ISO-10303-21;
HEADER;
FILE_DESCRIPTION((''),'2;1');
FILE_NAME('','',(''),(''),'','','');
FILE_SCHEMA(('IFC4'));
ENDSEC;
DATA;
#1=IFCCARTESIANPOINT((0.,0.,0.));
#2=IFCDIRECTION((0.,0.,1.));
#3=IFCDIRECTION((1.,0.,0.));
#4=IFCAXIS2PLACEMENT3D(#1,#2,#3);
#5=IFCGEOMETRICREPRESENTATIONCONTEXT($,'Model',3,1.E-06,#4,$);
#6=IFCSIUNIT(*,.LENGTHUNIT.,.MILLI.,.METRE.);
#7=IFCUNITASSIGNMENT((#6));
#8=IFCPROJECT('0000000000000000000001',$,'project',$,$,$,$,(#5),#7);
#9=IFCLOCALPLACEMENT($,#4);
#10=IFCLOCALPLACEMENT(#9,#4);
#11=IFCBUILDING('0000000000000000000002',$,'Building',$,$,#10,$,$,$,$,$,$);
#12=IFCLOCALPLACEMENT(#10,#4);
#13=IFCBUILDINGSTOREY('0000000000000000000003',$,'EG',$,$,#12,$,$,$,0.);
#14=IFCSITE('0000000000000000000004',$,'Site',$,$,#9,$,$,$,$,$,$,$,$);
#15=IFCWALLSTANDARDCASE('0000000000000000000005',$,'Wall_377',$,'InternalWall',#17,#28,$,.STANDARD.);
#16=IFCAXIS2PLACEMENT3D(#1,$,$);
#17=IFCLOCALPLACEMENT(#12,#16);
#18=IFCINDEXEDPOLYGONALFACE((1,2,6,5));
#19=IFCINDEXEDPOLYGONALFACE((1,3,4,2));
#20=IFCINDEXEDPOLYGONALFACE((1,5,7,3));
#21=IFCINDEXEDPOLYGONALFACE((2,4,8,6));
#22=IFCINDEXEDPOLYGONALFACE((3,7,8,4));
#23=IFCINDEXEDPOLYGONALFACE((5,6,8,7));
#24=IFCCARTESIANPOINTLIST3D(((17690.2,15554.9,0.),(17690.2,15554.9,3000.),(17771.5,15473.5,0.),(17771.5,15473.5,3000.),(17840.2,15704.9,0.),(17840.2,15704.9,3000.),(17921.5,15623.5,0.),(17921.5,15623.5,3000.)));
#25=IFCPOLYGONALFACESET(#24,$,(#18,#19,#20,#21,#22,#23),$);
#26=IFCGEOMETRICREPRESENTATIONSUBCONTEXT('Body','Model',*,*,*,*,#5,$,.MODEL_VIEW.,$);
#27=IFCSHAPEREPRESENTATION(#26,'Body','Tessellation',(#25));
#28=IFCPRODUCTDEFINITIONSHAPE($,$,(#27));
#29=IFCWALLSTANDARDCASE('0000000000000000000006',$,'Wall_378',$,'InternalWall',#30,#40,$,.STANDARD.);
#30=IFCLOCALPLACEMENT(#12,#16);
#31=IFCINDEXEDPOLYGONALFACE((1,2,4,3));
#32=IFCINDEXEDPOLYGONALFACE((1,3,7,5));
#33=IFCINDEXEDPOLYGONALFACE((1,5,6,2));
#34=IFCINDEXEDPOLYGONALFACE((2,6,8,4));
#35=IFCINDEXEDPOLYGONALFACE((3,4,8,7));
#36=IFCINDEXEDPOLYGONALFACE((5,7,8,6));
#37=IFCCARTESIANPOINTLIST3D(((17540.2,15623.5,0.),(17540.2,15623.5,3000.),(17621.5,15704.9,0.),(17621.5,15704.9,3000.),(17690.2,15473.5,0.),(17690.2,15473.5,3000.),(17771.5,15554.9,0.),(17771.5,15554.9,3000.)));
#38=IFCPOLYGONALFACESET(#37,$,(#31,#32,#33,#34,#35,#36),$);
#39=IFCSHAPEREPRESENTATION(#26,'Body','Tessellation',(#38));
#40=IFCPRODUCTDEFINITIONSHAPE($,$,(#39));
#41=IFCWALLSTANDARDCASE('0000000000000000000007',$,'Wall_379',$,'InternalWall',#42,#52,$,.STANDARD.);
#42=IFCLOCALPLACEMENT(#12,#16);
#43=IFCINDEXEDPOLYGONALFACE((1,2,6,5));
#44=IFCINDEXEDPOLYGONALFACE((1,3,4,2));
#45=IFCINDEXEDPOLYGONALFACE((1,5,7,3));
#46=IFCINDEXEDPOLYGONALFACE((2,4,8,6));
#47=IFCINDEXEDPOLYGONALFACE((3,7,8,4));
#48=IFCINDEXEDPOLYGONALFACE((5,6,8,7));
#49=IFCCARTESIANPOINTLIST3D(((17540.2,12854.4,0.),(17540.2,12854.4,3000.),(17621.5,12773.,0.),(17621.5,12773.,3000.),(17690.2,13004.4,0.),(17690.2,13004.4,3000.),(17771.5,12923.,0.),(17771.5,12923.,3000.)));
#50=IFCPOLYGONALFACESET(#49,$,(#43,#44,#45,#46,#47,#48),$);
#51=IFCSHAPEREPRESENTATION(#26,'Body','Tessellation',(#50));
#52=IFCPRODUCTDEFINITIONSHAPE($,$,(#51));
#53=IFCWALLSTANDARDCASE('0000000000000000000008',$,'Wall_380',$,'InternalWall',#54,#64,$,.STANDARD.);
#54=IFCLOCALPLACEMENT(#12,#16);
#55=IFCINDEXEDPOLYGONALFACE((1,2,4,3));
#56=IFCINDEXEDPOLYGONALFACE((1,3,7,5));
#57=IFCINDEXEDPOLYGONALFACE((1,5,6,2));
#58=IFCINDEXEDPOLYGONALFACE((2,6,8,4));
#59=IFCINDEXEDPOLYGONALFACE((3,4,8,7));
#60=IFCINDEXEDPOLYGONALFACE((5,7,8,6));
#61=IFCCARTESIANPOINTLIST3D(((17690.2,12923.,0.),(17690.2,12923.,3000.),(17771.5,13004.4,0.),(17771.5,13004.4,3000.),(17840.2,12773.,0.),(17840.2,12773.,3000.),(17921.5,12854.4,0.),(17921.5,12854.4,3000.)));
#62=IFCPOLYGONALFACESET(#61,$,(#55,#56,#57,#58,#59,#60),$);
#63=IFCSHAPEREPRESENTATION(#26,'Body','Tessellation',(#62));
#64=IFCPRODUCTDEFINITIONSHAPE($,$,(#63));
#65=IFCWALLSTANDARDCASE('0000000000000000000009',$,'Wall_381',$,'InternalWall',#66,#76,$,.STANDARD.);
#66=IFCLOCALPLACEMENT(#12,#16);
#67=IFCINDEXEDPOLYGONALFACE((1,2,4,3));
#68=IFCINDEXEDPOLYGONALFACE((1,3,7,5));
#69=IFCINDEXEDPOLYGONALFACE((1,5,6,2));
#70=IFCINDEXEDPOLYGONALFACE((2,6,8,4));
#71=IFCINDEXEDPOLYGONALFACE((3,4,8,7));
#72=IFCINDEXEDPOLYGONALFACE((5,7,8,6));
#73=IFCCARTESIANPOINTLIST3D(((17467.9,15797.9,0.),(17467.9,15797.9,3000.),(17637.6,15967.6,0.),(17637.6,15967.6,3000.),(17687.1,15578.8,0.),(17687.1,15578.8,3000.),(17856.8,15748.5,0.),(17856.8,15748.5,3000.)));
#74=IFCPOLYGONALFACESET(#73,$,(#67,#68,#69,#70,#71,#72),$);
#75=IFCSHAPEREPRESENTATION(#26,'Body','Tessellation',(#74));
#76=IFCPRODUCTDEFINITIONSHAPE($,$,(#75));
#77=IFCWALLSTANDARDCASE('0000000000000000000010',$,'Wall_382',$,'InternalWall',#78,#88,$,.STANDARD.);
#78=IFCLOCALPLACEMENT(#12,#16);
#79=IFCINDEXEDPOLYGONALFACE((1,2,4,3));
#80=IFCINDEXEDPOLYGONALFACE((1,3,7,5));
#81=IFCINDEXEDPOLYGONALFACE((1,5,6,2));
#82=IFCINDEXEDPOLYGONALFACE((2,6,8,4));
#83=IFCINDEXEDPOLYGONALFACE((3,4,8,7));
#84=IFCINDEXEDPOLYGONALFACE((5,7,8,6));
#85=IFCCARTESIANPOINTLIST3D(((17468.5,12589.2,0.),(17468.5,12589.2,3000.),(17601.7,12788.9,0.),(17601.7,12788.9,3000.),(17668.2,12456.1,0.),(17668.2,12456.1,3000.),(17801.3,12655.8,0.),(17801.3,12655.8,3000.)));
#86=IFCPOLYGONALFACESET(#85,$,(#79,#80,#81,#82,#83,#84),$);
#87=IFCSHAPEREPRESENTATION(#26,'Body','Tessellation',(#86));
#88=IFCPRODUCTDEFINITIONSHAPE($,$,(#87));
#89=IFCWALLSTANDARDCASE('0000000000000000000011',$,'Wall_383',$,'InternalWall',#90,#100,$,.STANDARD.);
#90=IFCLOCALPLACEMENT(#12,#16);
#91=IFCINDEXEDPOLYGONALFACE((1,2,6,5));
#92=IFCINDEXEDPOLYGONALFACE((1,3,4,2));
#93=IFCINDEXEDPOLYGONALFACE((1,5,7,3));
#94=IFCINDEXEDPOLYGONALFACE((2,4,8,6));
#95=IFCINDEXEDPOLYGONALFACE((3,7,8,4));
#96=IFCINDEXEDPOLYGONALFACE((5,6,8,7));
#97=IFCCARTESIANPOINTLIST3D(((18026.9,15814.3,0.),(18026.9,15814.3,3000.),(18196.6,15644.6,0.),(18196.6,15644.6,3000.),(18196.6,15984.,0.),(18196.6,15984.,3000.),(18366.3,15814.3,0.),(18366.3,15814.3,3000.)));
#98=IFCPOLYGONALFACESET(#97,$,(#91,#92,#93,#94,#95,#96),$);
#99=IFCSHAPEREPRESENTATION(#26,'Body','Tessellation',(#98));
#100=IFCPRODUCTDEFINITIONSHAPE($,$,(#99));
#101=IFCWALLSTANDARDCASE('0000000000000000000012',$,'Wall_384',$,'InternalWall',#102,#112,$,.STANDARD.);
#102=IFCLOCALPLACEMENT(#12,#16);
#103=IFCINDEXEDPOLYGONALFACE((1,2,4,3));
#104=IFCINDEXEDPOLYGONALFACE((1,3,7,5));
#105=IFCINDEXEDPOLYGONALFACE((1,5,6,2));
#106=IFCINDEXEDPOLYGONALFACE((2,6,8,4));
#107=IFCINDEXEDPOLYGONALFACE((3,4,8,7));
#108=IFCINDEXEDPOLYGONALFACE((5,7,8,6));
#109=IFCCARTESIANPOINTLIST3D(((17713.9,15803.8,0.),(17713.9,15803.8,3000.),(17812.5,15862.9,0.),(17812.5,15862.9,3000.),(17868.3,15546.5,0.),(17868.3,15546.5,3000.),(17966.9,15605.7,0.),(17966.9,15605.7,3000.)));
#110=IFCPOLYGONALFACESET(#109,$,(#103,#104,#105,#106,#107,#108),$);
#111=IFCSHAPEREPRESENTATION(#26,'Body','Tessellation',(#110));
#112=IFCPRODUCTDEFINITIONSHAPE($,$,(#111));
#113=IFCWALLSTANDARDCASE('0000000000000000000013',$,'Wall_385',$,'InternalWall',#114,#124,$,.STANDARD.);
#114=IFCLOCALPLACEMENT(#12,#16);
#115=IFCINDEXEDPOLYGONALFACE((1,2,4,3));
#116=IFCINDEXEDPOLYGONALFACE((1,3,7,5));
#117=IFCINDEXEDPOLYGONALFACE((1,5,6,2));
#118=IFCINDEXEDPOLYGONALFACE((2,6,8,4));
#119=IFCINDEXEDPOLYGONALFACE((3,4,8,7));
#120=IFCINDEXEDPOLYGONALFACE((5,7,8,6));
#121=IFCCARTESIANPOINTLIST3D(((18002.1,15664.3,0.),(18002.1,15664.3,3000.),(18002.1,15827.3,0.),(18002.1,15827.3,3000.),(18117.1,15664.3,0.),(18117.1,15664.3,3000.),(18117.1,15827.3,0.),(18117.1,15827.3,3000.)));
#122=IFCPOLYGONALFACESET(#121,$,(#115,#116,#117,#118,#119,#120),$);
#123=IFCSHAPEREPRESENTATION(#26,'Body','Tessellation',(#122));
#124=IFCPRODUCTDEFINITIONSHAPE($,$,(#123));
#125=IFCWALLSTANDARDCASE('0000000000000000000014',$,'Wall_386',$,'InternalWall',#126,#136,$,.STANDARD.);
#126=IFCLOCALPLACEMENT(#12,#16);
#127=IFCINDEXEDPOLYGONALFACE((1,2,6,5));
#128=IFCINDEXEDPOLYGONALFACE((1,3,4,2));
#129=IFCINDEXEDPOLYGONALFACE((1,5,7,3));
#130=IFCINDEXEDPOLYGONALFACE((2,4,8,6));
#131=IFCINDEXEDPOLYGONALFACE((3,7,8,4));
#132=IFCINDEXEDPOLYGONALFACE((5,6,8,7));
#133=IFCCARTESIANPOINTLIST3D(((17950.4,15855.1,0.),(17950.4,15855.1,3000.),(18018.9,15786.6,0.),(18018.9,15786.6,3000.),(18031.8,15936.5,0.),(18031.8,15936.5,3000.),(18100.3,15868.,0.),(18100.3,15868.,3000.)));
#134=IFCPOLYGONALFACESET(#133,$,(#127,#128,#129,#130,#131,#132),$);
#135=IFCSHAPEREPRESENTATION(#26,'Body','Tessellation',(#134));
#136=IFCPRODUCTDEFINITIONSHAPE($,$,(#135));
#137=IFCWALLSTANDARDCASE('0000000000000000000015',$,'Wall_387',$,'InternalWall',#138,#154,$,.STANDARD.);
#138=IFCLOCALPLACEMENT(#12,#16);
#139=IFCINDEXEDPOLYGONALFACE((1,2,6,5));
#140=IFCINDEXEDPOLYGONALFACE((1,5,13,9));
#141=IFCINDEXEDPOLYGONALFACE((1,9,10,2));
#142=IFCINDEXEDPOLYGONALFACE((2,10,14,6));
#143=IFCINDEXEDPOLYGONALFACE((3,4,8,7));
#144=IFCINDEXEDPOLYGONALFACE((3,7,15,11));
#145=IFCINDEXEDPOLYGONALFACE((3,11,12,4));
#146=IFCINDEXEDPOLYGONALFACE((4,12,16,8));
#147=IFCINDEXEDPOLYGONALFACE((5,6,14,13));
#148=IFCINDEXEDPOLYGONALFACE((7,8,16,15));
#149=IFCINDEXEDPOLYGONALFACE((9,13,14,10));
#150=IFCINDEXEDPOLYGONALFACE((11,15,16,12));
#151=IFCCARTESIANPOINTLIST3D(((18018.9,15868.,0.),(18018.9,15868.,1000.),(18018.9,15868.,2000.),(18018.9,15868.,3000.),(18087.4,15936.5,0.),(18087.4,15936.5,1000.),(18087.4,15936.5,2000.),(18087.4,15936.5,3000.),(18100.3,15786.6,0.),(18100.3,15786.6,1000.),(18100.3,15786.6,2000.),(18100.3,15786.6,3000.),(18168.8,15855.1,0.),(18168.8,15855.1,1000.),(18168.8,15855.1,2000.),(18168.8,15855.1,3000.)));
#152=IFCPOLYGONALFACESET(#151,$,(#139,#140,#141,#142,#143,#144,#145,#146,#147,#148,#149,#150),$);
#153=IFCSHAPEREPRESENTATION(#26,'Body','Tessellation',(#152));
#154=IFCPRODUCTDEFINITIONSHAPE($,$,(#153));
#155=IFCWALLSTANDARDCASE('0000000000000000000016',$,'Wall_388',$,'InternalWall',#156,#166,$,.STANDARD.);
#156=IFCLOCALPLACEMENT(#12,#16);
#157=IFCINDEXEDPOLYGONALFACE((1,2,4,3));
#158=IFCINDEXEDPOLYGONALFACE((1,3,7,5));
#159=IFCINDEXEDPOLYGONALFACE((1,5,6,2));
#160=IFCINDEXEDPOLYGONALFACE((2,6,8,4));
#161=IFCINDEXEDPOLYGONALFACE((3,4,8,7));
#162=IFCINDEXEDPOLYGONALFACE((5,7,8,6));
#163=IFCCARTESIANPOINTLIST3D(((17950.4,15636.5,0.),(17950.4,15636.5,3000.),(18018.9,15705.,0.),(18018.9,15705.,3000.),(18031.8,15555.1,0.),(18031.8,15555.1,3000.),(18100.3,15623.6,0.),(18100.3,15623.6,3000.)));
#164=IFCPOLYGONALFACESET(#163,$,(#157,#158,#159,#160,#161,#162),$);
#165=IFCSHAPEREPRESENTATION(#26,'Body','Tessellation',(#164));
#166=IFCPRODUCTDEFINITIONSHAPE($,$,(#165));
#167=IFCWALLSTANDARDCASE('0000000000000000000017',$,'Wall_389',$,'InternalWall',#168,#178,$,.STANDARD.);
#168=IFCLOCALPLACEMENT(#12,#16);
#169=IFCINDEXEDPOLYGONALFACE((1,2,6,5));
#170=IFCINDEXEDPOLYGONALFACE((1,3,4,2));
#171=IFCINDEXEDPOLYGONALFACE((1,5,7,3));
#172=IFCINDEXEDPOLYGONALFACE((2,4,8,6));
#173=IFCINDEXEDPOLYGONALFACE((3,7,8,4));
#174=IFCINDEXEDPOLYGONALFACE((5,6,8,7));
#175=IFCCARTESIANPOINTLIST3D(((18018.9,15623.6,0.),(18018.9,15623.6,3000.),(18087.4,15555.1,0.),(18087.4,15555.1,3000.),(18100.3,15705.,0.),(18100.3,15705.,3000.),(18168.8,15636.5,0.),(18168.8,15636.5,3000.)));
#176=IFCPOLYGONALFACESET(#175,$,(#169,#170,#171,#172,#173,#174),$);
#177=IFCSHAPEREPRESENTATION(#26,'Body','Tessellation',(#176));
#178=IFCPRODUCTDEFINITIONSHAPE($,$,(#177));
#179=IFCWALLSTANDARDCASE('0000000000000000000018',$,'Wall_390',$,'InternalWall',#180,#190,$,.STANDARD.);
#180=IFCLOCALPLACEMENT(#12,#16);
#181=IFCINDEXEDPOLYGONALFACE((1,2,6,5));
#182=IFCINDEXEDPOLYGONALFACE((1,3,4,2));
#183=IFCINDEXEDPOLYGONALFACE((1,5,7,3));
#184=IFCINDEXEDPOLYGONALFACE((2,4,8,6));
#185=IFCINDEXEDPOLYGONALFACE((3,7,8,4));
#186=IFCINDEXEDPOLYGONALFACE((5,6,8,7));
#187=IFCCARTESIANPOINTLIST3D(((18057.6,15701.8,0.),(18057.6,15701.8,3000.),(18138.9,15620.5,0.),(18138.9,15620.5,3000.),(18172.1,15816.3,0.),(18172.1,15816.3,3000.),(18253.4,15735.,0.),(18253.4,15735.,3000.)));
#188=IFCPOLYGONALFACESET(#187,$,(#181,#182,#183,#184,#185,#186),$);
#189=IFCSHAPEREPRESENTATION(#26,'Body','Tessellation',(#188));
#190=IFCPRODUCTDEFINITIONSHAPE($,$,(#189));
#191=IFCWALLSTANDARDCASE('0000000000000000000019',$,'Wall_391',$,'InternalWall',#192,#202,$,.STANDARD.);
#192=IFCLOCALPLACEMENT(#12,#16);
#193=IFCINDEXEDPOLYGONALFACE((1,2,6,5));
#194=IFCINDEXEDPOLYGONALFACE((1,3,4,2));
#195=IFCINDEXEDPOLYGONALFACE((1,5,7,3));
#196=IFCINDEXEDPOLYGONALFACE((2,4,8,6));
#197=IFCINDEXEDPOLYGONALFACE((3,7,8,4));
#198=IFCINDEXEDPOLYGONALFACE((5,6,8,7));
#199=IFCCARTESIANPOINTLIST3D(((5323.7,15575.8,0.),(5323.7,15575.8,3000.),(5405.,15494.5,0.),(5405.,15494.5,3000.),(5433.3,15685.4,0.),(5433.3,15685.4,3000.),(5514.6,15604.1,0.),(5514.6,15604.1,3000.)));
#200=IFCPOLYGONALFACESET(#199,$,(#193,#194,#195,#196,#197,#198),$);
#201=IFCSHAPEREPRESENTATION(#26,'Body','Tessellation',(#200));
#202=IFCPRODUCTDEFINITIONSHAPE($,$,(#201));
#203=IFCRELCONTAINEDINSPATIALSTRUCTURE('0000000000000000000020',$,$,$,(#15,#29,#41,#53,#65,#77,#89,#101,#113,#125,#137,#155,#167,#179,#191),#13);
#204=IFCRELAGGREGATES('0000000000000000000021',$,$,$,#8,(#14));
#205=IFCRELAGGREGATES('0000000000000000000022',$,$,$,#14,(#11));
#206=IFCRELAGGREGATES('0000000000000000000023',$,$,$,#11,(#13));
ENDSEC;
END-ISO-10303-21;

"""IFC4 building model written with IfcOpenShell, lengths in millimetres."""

from ifc_helpers import new_model, si_unit, frame, origin_with_axes, place, context, subcontext, project, spatial, rectangle, extrude, element, save


model = new_model("IFC4")

# Units and contexts
model_context = context("Model", 3, precision=1e-06, world=origin_with_axes())
body_context = subcontext(model_context, "Body", "Model", "MODEL_VIEW")
ifc_project = project(units=[si_unit("LENGTHUNIT", "METRE", prefix="MILLI")], contexts=[model_context])

# Site, building, storey
site_placement = place(None, origin_with_axes())
site = spatial("IfcSite", under=ifc_project, at=site_placement, Name="Site")
building_placement = place(site_placement, origin_with_axes())
building = spatial("IfcBuilding", under=site, at=building_placement, Name="Building")
storey_placement = place(building_placement, origin_with_axes())
storey = spatial("IfcBuildingStorey", under=building, at=storey_placement, Name="EG", Elevation=0.0)

# Walls
wall_1_placement = place(storey_placement, origin_with_axes())
element("IfcWallStandardCase", 1, at=wall_1_placement, inside=storey, Name="Wall_377", ObjectType="InternalWall", PredefinedType="STANDARD", context=body_context, shape_type="SweptSolid", body=[
    extrude(rectangle(XDim=212.1, YDim=115.0), frame((17805.8, 15589.2, 0.0), z_axis=(0.0, 0.0, 1.0), x_axis=(-0.707107, -0.707107, 0.0)), (0.0, 0.0, 1.0), 3000.0),
])
wall_2_placement = place(storey_placement, origin_with_axes())
element("IfcWallStandardCase", 2, at=wall_2_placement, inside=storey, Name="Wall_378", ObjectType="InternalWall", PredefinedType="STANDARD", context=body_context, shape_type="SweptSolid", body=[
    extrude(rectangle(XDim=212.1, YDim=115.0), frame((17655.8, 15589.2, 0.0), z_axis=(0.0, 0.0, 1.0), x_axis=(-0.707107, 0.707107, 0.0)), (0.0, 0.0, 1.0), 3000.0),
])
wall_3_placement = place(storey_placement, origin_with_axes())
element("IfcWallStandardCase", 3, at=wall_3_placement, inside=storey, Name="Wall_379", ObjectType="InternalWall", PredefinedType="STANDARD", context=body_context, shape_type="SweptSolid", body=[
    extrude(rectangle(XDim=212.1, YDim=115.0), frame((17655.8, 12888.7, 0.0), z_axis=(0.0, 0.0, 1.0), x_axis=(-0.707107, -0.707107, 0.0)), (0.0, 0.0, 1.0), 3000.0),
])
wall_4_placement = place(storey_placement, origin_with_axes())
element("IfcWallStandardCase", 4, at=wall_4_placement, inside=storey, Name="Wall_380", ObjectType="InternalWall", PredefinedType="STANDARD", context=body_context, shape_type="SweptSolid", body=[
    extrude(rectangle(XDim=212.1, YDim=115.0), frame((17805.8, 12888.7, 0.0), z_axis=(0.0, 0.0, 1.0), x_axis=(0.707107, -0.707107, 0.0)), (0.0, 0.0, 1.0), 3000.0),
])
wall_5_placement = place(storey_placement, origin_with_axes())
element("IfcWallStandardCase", 5, at=wall_5_placement, inside=storey, Name="Wall_381", ObjectType="InternalWall", PredefinedType="STANDARD", context=body_context, shape_type="SweptSolid", body=[
    extrude(rectangle(XDim=310.0, YDim=240.0), frame((17662.3, 15773.2, 0.0), z_axis=(0.0, 0.0, 1.0), x_axis=(-0.707107, 0.707107, 0.0)), (0.0, 0.0, 1.0), 3000.0),
])
wall_6_placement = place(storey_placement, origin_with_axes())
element("IfcWallStandardCase", 6, at=wall_6_placement, inside=storey, Name="Wall_382", ObjectType="InternalWall", PredefinedType="STANDARD", context=body_context, shape_type="SweptSolid", body=[
    extrude(rectangle(XDim=240.0, YDim=240.0), frame((17634.9, 12622.5, 0.0), z_axis=(0.0, 0.0, 1.0), x_axis=(-0.83205, 0.5547, 0.0)), (0.0, 0.0, 1.0), 3000.0),
])
wall_7_placement = place(storey_placement, origin_with_axes())
element("IfcWallStandardCase", 7, at=wall_7_placement, inside=storey, Name="Wall_383", ObjectType="InternalWall", PredefinedType="STANDARD", context=body_context, shape_type="SweptSolid", body=[
    extrude(rectangle(XDim=240.0, YDim=240.0), frame((18196.6, 15814.3, 0.0), z_axis=(0.0, 0.0, 1.0), x_axis=(-0.707107, 0.707107, 0.0)), (0.0, 0.0, 1.0), 3000.0),
])
wall_8_placement = place(storey_placement, origin_with_axes())
element("IfcWallStandardCase", 8, at=wall_8_placement, inside=storey, Name="Wall_384", ObjectType="InternalWall", PredefinedType="STANDARD", context=body_context, shape_type="SweptSolid", body=[
    extrude(rectangle(XDim=300.0, YDim=115.0), frame((17840.4, 15704.7, 0.0), z_axis=(0.0, 0.0, 1.0), x_axis=(-0.514496, 0.857493, 0.0)), (0.0, 0.0, 1.0), 3000.0),
])
wall_9_placement = place(storey_placement, origin_with_axes())
element("IfcWallStandardCase", 9, at=wall_9_placement, inside=storey, Name="Wall_385", ObjectType="InternalWall", PredefinedType="STANDARD", context=body_context, shape_type="SweptSolid", body=[
    extrude(rectangle(XDim=163.0, YDim=115.0), frame((18059.6, 15745.8, 0.0), z_axis=(0.0, 0.0, 1.0), x_axis=(0.0, -1.0, 0.0)), (0.0, 0.0, 1.0), 3000.0),
])
wall_10_placement = place(storey_placement, origin_with_axes())
element("IfcWallStandardCase", 10, at=wall_10_placement, inside=storey, Name="Wall_386", ObjectType="InternalWall", PredefinedType="STANDARD", context=body_context, shape_type="SweptSolid", body=[
    extrude(rectangle(XDim=96.9, YDim=115.0), frame((18025.3, 15861.6, 0.0), z_axis=(0.0, 0.0, 1.0), x_axis=(0.707107, -0.707107, 0.0)), (0.0, 0.0, 1.0), 3000.0),
])

# Wall, opening
wall_11_placement = place(storey_placement, origin_with_axes())
wall_11 = element("IfcWallStandardCase", 11, at=wall_11_placement, inside=storey, Name="Wall_387", ObjectType="InternalWall", PredefinedType="STANDARD", context=body_context, shape_type="SweptSolid", body=[
    extrude(rectangle(XDim=96.9, YDim=115.0), frame((18093.8, 15861.6, 0.0), z_axis=(0.0, 0.0, 1.0), x_axis=(0.707107, 0.707107, 0.0)), (0.0, 0.0, 1.0), 3000.0),
])
opening_1_placement = place(wall_11_placement, origin_with_axes())
element("IfcOpeningElement", 12, at=opening_1_placement, inside=storey, cuts=wall_11, context=body_context, shape_type="SweptSolid", body=[
    extrude(rectangle(XDim=2586.9, YDim=115.0), frame((18026.5, 15794.2, 1000.0), z_axis=(0.0, 0.0, 1.0), x_axis=(0.707107, 0.707107, 0.0)), (0.0, 0.0, 1.0), 1000.0),
])

# Walls
wall_12_placement = place(storey_placement, origin_with_axes())
element("IfcWallStandardCase", 13, at=wall_12_placement, inside=storey, Name="Wall_388", ObjectType="InternalWall", PredefinedType="STANDARD", context=body_context, shape_type="SweptSolid", body=[
    extrude(rectangle(XDim=96.9, YDim=115.0), frame((18025.3, 15630.1, 0.0), z_axis=(0.0, 0.0, 1.0), x_axis=(-0.707107, -0.707107, 0.0)), (0.0, 0.0, 1.0), 3000.0),
])
wall_13_placement = place(storey_placement, origin_with_axes())
element("IfcWallStandardCase", 14, at=wall_13_placement, inside=storey, Name="Wall_389", ObjectType="InternalWall", PredefinedType="STANDARD", context=body_context, shape_type="SweptSolid", body=[
    extrude(rectangle(XDim=96.9, YDim=115.0), frame((18093.8, 15630.1, 0.0), z_axis=(0.0, 0.0, 1.0), x_axis=(0.707107, -0.707107, 0.0)), (0.0, 0.0, 1.0), 3000.0),
])
wall_14_placement = place(storey_placement, origin_with_axes())
element("IfcWallStandardCase", 15, at=wall_14_placement, inside=storey, Name="Wall_390", ObjectType="InternalWall", PredefinedType="STANDARD", context=body_context, shape_type="SweptSolid", body=[
    extrude(rectangle(XDim=161.9, YDim=115.0), frame((18155.5, 15718.4, 0.0), z_axis=(0.0, 0.0, 1.0), x_axis=(-0.707107, -0.707107, 0.0)), (0.0, 0.0, 1.0), 3000.0),
])
wall_15_placement = place(storey_placement, origin_with_axes())
element("IfcWallStandardCase", 16, at=wall_15_placement, inside=storey, Name="Wall_391", ObjectType="InternalWall", PredefinedType="STANDARD", context=body_context, shape_type="SweptSolid", body=[
    extrude(rectangle(XDim=155.0, YDim=115.0), frame((5419.2, 15590.0, 0.0), z_axis=(0.0, 0.0, 1.0), x_axis=(0.707107, 0.707107, 0.0)), (0.0, 0.0, 1.0), 3000.0),
])

save(model, "model.ifc")
